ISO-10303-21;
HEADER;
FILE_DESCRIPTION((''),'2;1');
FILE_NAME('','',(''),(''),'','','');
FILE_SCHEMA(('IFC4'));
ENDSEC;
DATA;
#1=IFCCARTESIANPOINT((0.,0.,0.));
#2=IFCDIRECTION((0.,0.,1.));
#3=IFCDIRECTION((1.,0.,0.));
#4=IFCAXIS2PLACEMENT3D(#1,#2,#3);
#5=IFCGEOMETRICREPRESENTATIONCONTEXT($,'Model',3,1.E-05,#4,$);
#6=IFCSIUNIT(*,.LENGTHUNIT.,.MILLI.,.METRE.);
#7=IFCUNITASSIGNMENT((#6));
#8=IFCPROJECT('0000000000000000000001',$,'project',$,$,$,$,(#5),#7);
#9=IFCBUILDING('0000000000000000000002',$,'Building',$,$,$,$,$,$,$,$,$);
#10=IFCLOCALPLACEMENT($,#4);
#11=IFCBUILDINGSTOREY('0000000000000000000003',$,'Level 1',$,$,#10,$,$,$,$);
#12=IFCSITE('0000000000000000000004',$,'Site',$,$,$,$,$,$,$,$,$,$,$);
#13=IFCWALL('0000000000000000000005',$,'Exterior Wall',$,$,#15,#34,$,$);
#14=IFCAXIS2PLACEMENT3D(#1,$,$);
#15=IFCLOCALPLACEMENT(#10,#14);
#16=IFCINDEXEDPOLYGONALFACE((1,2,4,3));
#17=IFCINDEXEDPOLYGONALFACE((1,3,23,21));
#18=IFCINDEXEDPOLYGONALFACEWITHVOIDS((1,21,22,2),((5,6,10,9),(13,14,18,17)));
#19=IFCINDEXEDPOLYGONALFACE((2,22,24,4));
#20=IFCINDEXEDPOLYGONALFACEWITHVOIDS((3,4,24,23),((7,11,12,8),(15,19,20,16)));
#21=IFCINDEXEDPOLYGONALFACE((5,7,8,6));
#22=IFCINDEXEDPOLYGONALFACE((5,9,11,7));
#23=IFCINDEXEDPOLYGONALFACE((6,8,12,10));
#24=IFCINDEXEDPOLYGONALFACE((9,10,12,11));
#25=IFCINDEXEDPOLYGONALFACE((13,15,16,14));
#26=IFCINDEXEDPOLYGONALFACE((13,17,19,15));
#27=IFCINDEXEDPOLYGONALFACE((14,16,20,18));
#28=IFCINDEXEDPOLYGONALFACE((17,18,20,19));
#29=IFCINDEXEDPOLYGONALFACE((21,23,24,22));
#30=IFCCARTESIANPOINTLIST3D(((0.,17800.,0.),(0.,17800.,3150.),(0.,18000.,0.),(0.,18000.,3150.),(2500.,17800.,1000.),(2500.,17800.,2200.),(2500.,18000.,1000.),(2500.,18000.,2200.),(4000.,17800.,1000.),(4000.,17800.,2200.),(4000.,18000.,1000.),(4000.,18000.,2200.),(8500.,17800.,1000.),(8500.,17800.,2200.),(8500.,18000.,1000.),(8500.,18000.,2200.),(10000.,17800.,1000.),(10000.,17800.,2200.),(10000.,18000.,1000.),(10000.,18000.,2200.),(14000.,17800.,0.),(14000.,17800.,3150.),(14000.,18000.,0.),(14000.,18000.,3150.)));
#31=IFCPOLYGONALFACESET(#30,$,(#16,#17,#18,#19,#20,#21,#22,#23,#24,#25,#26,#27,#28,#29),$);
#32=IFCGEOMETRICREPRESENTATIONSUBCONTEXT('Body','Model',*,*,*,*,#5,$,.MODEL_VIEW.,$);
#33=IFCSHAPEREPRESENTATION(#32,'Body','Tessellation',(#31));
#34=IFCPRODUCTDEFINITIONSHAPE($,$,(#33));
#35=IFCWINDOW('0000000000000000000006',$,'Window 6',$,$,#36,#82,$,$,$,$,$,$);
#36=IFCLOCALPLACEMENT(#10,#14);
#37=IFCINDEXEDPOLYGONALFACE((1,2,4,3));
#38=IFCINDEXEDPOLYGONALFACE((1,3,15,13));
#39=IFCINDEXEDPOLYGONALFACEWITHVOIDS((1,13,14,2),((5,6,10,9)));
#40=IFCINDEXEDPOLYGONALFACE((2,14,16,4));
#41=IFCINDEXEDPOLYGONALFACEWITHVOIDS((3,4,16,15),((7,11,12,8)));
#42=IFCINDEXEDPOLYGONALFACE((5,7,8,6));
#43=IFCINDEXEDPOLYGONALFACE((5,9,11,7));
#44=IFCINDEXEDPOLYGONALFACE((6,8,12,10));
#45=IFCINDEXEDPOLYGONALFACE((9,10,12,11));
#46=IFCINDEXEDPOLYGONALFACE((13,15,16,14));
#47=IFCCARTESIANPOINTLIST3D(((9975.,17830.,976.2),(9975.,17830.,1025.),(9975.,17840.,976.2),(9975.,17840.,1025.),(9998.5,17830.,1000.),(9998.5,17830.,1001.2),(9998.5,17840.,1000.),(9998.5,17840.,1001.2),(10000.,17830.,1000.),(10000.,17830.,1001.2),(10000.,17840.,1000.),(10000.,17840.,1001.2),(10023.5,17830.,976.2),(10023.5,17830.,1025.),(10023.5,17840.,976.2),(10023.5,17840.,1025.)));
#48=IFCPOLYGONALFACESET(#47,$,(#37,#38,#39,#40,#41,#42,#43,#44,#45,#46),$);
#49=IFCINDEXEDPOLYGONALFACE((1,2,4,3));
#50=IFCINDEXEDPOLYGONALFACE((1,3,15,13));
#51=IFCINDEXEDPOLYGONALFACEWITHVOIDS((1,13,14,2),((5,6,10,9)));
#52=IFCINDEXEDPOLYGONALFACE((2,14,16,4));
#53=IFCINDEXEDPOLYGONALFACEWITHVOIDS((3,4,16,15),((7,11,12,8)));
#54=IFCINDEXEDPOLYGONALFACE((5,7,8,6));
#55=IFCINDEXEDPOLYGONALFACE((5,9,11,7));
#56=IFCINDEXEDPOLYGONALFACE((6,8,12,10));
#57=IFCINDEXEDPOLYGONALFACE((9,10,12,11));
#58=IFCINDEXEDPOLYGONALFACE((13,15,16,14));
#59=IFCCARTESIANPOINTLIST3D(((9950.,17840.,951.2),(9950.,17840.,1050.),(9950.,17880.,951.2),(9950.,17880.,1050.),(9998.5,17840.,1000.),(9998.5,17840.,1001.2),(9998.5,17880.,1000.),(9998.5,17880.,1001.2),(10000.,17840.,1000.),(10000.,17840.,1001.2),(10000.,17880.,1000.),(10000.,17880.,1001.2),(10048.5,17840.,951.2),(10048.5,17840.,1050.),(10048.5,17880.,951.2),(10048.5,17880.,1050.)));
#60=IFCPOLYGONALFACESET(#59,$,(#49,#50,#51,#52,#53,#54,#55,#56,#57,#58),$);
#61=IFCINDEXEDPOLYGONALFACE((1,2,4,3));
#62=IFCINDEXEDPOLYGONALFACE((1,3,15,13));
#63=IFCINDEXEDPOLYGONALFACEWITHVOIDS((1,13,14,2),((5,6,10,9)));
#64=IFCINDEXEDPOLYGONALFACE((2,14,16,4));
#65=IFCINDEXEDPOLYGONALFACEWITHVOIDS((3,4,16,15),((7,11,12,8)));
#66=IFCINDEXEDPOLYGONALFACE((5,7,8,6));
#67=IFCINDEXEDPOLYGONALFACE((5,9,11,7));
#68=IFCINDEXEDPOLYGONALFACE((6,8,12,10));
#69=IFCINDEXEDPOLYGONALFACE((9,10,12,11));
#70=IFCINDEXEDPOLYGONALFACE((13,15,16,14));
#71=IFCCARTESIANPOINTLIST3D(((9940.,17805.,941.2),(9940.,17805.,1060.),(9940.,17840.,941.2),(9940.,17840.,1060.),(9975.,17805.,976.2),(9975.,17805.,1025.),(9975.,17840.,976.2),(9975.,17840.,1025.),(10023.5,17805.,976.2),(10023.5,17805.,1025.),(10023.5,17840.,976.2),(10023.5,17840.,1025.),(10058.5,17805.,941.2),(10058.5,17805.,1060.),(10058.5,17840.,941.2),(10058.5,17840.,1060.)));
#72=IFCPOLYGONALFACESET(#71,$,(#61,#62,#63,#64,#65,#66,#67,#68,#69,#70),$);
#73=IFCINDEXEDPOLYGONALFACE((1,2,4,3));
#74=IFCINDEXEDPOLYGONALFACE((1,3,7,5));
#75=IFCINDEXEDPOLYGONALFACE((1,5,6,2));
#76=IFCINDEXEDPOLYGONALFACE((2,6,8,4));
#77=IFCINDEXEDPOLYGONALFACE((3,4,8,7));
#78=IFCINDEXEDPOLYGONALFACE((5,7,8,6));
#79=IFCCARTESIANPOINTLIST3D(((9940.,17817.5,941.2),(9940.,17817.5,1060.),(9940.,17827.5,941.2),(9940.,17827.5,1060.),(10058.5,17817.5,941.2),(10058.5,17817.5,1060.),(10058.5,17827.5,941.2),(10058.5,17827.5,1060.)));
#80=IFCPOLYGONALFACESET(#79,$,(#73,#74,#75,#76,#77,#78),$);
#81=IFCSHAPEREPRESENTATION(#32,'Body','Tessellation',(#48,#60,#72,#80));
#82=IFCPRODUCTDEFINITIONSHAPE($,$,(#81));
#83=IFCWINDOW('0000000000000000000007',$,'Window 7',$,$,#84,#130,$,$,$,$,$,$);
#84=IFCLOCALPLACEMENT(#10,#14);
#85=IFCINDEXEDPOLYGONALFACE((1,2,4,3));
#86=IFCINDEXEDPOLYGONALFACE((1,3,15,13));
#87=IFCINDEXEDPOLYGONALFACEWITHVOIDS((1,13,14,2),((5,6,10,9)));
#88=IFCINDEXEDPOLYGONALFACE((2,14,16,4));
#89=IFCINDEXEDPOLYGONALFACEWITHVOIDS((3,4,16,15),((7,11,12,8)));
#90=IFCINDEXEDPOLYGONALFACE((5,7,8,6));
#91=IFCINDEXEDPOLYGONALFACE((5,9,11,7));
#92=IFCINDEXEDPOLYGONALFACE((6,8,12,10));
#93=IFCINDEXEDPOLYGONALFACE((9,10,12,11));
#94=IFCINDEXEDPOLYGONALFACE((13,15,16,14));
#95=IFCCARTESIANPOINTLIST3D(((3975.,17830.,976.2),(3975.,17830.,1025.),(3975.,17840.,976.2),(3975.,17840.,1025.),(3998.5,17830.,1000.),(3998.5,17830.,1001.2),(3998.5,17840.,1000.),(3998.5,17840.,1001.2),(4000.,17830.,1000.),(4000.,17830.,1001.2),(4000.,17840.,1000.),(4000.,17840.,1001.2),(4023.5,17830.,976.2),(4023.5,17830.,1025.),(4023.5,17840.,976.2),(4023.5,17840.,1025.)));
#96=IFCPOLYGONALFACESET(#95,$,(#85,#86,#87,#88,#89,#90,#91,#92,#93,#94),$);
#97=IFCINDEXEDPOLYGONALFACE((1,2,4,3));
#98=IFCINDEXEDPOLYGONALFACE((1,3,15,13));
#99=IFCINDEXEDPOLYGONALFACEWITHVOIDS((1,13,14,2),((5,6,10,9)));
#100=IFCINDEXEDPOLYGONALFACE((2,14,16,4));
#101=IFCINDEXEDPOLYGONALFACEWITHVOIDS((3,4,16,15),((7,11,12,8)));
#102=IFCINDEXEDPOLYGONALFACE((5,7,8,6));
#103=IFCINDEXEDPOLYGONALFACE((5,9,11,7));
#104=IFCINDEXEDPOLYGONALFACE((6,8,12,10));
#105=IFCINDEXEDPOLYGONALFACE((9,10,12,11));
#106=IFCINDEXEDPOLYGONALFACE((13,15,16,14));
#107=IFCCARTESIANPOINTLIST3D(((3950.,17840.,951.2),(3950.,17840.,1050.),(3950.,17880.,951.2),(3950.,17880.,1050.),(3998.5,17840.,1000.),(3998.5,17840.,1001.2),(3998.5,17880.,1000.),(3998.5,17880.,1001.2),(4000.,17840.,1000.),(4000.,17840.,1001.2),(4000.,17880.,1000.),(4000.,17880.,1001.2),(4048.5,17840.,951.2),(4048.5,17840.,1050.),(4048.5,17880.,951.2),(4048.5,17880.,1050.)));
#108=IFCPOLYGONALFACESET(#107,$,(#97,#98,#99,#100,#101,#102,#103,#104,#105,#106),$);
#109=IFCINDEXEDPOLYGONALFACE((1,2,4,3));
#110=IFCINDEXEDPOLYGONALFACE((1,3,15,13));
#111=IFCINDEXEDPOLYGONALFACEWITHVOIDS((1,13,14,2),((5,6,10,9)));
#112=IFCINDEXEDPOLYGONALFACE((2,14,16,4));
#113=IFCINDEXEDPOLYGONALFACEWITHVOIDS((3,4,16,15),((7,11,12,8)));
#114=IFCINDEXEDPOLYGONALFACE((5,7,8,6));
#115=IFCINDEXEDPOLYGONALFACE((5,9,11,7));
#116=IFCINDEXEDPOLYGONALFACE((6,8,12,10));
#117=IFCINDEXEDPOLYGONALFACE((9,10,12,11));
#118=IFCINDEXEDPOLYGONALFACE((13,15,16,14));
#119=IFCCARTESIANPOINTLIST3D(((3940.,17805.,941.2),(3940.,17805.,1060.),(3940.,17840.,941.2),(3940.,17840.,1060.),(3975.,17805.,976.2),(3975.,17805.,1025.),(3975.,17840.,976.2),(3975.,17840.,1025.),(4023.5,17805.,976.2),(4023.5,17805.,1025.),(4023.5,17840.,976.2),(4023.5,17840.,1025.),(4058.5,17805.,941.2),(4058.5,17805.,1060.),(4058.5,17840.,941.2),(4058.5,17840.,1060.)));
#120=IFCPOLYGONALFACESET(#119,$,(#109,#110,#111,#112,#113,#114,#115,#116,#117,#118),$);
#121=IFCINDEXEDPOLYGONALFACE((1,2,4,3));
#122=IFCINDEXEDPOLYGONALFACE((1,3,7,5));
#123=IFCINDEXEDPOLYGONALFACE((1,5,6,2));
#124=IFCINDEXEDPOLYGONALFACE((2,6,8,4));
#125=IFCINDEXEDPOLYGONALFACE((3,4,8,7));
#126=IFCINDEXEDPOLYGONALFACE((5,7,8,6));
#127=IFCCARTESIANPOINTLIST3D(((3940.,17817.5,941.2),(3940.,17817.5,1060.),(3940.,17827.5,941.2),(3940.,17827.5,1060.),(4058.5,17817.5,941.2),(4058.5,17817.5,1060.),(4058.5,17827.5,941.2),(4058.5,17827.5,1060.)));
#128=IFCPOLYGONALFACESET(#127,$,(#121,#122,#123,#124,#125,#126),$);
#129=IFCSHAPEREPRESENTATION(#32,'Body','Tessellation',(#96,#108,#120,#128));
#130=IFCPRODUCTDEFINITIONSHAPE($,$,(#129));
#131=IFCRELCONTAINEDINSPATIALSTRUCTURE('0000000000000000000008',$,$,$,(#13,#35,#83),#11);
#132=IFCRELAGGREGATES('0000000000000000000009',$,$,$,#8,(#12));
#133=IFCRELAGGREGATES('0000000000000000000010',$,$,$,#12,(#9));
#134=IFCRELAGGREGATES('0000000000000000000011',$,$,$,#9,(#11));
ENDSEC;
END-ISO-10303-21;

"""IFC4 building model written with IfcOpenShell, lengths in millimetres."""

from ifc_helpers import new_model, si_unit, frame, origin_with_axes, place, context, subcontext, project, spatial, line, indexed_curve, outline, extrude, element, fill, save


model = new_model("IFC4")

# Units and contexts
model_context = context("Model", 3, precision=1e-05, world=origin_with_axes())
body_context = subcontext(model_context, "Body", "Model", "MODEL_VIEW")
ifc_project = project(units=[si_unit("LENGTHUNIT", "METRE", prefix="MILLI")], contexts=[model_context])

# Site, building, storey
site = spatial("IfcSite", under=ifc_project, Name="Site")
building = spatial("IfcBuilding", under=site, Name="Building")
storey_placement = place(None, origin_with_axes())
storey = spatial("IfcBuildingStorey", under=building, at=storey_placement, Name="Level 1")

# Wall, openings, windows
wall_1_placement = place(storey_placement, frame((14000.0, 18000.0, 0.0), z_axis=(0.0, 0.0, 1.0), x_axis=(-1.0, 0.0, 0.0)))
wall_1 = element("IfcWall", 1, at=wall_1_placement, inside=storey, Name="Exterior Wall", context=body_context, shape_type="SweptSolid", body=[
    extrude(outline(indexed_curve([(0.0, 0.0), (0.0, 200.0), (14000.0, 200.0), (14000.0, 0.0), (0.0, 0.0)], self_intersect=False)), origin_with_axes(), (0.0, 0.0, 1.0), 3150.0),
])
opening_1_placement = place(wall_1_placement, frame((4000.0, -100.0, 1000.0), z_axis=(0.0, 0.0, 1.0), x_axis=(1.0, 0.0, 0.0)))
opening_1 = element("IfcOpeningElement", 2, at=opening_1_placement, cuts=wall_1, context=body_context, shape_type="SweptSolid", body=[
    extrude(outline(indexed_curve([(0.0, 0.0), (0.0, 400.0), (1500.0, 400.0), (1500.0, 0.0), (0.0, 0.0)], self_intersect=False)), origin_with_axes(), (0.0, 0.0, 1.0), 1200.0),
])
opening_2_placement = place(wall_1_placement, frame((10000.0, -100.0, 1000.0), z_axis=(0.0, 0.0, 1.0), x_axis=(1.0, 0.0, 0.0)))
opening_2 = element("IfcOpeningElement", 3, at=opening_2_placement, cuts=wall_1, context=body_context, shape_type="SweptSolid", body=[
    extrude(outline(indexed_curve([(0.0, 0.0), (0.0, 400.0), (1500.0, 400.0), (1500.0, 0.0), (0.0, 0.0)], self_intersect=False)), origin_with_axes(), (0.0, 0.0, 1.0), 1200.0),
])
window_1_placement = place(opening_1_placement, frame((0.0, 170.0, 0.0), z_axis=(0.0, 0.0, 1.0), x_axis=(1.0, 0.0, 0.0)))
window_1 = element("IfcWindow", 4, at=window_1_placement, inside=storey, Name="Window 6", context=body_context, shape_type="SweptSolid", body=[
    extrude(outline(indexed_curve([(0.0, 0.0), (1.5, 0.0), (1.5, 1.2), (0.0, 1.2)], segments=[line(1, 2, 3, 4, 1)]), holes=[indexed_curve([(25.0, 25.0), (-23.5, 25.0), (-23.5, -23.8), (25.0, -23.8)], segments=[line(1, 2, 3, 4, 1)])]), frame((0.0, 90.0, 0.0), z_axis=(0.0, -1.0, 0.0), x_axis=(1.0, 0.0, 0.0)), (0.0, 0.0, -1.0), 10.0),
    extrude(outline(indexed_curve([(0.0, 0.0), (1.5, 0.0), (1.5, 1.2), (0.0, 1.2)], segments=[line(1, 2, 3, 4, 1)]), holes=[indexed_curve([(50.0, 50.0), (-48.5, 50.0), (-48.5, -48.8), (50.0, -48.8)], segments=[line(1, 2, 3, 4, 1)])]), frame((0.0, 50.0, 0.0), z_axis=(0.0, -1.0, 0.0), x_axis=(1.0, 0.0, 0.0)), (0.0, 0.0, -1.0), 40.0),
    extrude(outline(indexed_curve([(0.0, 0.0), (-48.5, 0.0), (-48.5, -48.8), (0.0, -48.8)], segments=[line(1, 2, 3, 4, 1)]), holes=[indexed_curve([(35.0, 35.0), (-83.5, 35.0), (-83.5, -83.8), (35.0, -83.8)], segments=[line(1, 2, 3, 4, 1)])]), frame((25.0, 90.0, 25.0), z_axis=(0.0, -1.0, 0.0), x_axis=(1.0, 0.0, 0.0)), (0.0, 0.0, -1.0), 35.0),
    extrude(outline(indexed_curve([(35.0, 35.0), (-83.5, 35.0), (-83.5, -83.8), (35.0, -83.8)], segments=[line(1, 2, 3, 4, 1)])), frame((25.0, 102.5, 25.0), z_axis=(0.0, -1.0, 0.0), x_axis=(1.0, 0.0, 0.0)), (0.0, 0.0, -1.0), 10.0),
])
fill(opening_1, window_1)
window_2_placement = place(opening_2_placement, frame((0.0, 170.0, 0.0), z_axis=(0.0, 0.0, 1.0), x_axis=(1.0, 0.0, 0.0)))
window_2 = element("IfcWindow", 5, at=window_2_placement, inside=storey, Name="Window 7", context=body_context, shape_type="SweptSolid", body=[
    extrude(outline(indexed_curve([(0.0, 0.0), (1.5, 0.0), (1.5, 1.2), (0.0, 1.2)], segments=[line(1, 2, 3, 4, 1)]), holes=[indexed_curve([(25.0, 25.0), (-23.5, 25.0), (-23.5, -23.8), (25.0, -23.8)], segments=[line(1, 2, 3, 4, 1)])]), frame((0.0, 90.0, 0.0), z_axis=(0.0, -1.0, 0.0), x_axis=(1.0, 0.0, 0.0)), (0.0, 0.0, -1.0), 10.0),
    extrude(outline(indexed_curve([(0.0, 0.0), (1.5, 0.0), (1.5, 1.2), (0.0, 1.2)], segments=[line(1, 2, 3, 4, 1)]), holes=[indexed_curve([(50.0, 50.0), (-48.5, 50.0), (-48.5, -48.8), (50.0, -48.8)], segments=[line(1, 2, 3, 4, 1)])]), frame((0.0, 50.0, 0.0), z_axis=(0.0, -1.0, 0.0), x_axis=(1.0, 0.0, 0.0)), (0.0, 0.0, -1.0), 40.0),
    extrude(outline(indexed_curve([(0.0, 0.0), (-48.5, 0.0), (-48.5, -48.8), (0.0, -48.8)], segments=[line(1, 2, 3, 4, 1)]), holes=[indexed_curve([(35.0, 35.0), (-83.5, 35.0), (-83.5, -83.8), (35.0, -83.8)], segments=[line(1, 2, 3, 4, 1)])]), frame((25.0, 90.0, 25.0), z_axis=(0.0, -1.0, 0.0), x_axis=(1.0, 0.0, 0.0)), (0.0, 0.0, -1.0), 35.0),
    extrude(outline(indexed_curve([(35.0, 35.0), (-83.5, 35.0), (-83.5, -83.8), (35.0, -83.8)], segments=[line(1, 2, 3, 4, 1)])), frame((25.0, 102.5, 25.0), z_axis=(0.0, -1.0, 0.0), x_axis=(1.0, 0.0, 0.0)), (0.0, 0.0, -1.0), 10.0),
])
fill(opening_2, window_2)

save(model, "model.ifc")
